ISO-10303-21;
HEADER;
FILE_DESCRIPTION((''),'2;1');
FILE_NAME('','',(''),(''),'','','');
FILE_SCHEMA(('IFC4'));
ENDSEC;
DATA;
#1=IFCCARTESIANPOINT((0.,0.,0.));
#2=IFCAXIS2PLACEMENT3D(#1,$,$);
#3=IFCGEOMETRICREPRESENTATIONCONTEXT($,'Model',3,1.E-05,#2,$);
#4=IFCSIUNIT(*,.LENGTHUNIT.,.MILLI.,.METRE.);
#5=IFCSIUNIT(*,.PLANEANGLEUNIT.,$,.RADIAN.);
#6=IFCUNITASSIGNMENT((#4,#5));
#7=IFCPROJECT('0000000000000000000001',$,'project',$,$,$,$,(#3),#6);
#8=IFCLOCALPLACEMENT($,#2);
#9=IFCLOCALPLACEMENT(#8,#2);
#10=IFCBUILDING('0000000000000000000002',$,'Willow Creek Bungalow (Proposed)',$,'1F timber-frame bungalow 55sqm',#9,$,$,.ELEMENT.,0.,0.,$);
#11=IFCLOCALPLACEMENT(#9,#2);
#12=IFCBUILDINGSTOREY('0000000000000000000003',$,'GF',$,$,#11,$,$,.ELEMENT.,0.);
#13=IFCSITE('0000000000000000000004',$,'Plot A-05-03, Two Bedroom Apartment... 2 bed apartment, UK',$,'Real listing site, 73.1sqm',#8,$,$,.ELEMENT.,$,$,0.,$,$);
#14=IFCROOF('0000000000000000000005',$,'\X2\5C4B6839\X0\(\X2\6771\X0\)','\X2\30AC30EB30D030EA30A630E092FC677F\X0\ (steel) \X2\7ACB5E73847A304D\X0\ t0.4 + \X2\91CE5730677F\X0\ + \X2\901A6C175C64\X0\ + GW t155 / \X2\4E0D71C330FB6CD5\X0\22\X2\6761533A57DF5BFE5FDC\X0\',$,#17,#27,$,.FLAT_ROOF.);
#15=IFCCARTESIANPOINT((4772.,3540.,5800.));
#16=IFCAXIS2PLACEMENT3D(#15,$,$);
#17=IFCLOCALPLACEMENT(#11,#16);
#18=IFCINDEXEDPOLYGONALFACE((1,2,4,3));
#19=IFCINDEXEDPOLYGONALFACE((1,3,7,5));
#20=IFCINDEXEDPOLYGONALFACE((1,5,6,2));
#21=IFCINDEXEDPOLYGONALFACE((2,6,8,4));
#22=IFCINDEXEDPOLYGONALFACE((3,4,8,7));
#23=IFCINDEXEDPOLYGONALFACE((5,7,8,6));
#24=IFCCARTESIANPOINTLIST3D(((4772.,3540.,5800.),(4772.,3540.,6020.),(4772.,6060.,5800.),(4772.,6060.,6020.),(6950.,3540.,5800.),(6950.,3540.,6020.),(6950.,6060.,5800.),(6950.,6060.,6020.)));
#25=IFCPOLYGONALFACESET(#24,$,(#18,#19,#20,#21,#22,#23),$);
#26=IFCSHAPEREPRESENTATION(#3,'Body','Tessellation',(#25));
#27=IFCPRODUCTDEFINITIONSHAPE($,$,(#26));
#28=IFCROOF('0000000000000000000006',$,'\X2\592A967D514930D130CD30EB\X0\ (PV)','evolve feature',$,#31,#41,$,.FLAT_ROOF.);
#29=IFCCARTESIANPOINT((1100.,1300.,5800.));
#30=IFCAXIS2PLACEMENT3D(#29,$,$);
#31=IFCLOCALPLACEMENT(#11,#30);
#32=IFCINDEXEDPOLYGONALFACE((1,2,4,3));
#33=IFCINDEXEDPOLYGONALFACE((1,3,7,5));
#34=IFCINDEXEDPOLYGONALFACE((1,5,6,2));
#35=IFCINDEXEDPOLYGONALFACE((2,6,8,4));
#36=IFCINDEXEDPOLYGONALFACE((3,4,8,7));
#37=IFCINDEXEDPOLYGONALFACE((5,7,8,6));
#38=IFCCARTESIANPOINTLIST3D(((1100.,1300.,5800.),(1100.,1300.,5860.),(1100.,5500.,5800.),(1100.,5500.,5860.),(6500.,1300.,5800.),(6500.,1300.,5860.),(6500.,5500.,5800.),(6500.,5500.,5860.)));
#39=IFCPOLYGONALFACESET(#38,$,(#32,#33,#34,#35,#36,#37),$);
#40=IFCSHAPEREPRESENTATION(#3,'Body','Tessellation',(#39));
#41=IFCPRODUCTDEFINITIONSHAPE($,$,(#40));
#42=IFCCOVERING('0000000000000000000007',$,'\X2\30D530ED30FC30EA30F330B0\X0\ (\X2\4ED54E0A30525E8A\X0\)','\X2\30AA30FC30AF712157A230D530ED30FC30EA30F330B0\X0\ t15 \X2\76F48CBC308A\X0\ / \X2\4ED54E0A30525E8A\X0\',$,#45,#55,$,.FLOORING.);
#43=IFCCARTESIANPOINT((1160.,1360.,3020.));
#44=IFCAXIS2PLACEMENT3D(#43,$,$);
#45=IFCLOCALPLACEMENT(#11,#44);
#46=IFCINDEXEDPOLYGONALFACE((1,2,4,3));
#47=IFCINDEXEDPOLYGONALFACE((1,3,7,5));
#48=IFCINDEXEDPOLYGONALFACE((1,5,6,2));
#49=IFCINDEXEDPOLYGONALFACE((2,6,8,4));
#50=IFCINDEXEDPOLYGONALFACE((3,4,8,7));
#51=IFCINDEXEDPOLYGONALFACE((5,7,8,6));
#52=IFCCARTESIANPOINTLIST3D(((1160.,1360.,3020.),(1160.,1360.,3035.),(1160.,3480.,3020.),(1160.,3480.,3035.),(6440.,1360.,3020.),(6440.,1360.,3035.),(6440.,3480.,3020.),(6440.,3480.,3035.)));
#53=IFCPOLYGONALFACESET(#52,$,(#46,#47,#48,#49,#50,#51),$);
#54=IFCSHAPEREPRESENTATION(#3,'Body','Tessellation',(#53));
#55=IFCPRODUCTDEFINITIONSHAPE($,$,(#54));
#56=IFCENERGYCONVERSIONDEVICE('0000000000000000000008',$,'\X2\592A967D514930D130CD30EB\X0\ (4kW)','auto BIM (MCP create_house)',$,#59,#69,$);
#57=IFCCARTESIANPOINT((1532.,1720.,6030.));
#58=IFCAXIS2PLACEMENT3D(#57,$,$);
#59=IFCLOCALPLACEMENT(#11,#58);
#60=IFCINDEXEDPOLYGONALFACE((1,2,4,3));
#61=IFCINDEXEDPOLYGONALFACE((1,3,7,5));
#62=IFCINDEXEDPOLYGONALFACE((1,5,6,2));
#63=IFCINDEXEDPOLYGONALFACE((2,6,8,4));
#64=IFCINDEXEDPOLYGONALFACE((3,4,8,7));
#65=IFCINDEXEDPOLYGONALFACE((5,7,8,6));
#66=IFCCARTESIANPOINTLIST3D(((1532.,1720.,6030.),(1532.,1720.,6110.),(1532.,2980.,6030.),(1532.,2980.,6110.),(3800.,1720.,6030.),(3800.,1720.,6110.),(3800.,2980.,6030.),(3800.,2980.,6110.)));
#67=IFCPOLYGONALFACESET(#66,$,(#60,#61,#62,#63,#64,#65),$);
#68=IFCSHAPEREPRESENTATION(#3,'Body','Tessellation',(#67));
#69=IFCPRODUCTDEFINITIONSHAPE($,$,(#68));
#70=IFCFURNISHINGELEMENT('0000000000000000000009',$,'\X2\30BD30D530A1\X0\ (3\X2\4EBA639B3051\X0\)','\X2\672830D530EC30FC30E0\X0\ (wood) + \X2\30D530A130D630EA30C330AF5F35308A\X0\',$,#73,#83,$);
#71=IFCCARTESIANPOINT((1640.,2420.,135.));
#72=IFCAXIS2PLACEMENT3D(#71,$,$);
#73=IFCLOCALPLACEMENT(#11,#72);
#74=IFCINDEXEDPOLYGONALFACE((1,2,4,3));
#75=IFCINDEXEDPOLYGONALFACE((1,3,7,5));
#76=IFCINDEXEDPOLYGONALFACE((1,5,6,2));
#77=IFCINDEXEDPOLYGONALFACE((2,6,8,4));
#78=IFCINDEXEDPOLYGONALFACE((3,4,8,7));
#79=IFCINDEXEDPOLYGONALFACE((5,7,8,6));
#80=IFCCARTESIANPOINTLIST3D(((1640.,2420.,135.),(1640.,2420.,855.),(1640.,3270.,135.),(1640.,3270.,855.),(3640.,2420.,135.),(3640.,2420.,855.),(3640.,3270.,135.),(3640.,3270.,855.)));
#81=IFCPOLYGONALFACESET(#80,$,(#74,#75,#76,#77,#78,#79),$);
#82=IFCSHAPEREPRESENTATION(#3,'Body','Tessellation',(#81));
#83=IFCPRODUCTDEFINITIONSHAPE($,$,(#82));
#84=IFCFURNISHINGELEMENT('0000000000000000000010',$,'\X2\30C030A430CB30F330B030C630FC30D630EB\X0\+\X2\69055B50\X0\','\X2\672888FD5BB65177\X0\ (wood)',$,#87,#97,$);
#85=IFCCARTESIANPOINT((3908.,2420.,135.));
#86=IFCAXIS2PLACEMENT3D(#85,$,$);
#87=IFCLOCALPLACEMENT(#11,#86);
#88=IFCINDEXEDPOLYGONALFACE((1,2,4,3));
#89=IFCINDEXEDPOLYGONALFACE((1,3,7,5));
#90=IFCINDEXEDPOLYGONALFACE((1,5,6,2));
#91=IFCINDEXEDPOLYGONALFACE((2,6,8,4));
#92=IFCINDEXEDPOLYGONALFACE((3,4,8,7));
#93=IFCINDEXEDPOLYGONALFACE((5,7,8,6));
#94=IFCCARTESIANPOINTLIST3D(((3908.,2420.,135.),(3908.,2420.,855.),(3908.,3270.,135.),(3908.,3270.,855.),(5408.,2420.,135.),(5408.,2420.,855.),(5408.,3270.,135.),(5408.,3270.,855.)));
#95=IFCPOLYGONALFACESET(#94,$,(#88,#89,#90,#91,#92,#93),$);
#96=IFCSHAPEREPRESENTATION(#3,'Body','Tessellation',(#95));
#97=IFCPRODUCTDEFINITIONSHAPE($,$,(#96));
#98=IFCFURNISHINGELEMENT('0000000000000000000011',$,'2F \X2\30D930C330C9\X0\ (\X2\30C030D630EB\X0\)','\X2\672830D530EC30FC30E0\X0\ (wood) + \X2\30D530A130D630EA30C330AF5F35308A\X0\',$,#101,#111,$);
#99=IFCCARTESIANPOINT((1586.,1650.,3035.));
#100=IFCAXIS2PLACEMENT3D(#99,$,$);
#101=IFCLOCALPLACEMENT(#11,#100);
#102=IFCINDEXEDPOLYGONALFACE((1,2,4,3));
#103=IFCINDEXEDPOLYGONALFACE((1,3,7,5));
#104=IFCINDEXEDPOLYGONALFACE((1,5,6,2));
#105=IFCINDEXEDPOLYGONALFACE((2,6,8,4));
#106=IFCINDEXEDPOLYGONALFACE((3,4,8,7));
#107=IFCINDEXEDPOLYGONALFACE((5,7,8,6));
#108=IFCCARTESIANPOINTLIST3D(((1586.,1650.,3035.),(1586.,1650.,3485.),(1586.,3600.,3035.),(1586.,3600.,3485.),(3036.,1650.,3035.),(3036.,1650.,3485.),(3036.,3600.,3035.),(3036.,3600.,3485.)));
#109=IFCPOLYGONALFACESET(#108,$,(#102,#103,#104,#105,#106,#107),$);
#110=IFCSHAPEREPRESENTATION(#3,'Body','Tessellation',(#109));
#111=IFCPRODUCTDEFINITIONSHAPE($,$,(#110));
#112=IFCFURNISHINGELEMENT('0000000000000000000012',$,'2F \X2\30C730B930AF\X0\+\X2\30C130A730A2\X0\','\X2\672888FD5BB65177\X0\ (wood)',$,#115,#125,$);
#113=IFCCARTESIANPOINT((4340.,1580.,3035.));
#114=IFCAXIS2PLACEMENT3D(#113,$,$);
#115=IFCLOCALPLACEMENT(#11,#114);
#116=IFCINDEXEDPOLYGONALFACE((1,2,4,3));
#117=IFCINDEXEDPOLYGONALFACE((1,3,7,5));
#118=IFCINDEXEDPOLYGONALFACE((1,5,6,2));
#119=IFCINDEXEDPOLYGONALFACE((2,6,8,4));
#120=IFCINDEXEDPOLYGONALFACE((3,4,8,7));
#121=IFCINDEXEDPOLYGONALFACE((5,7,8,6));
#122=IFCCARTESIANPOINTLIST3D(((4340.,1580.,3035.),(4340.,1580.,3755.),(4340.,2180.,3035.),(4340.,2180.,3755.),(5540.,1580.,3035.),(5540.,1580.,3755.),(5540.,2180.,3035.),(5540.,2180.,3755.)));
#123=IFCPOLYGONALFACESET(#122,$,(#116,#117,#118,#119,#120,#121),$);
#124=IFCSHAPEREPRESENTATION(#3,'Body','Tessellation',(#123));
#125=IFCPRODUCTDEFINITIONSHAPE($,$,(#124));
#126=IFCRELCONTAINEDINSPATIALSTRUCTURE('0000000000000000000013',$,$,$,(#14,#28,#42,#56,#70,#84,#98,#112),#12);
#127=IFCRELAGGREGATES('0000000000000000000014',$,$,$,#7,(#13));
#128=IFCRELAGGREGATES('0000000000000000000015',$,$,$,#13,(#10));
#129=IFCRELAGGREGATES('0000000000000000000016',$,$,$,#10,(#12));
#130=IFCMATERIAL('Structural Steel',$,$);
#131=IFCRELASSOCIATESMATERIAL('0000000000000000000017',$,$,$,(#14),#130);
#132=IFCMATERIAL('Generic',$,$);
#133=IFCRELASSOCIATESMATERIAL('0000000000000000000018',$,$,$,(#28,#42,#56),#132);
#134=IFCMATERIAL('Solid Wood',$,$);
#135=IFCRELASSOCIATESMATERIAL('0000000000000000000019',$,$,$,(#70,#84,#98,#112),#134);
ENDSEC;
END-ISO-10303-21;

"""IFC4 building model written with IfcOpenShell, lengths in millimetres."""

from ifc_helpers import new_model, si_unit, frame, frame_2d, origin, place, context, project, spatial, rectangle, extrude, material, element, save


model = new_model("IFC4")

# Units and contexts
model_context = context("Model", 3, precision=1e-05, world=origin())
ifc_project = project(units=[si_unit("LENGTHUNIT", "METRE", prefix="MILLI"), si_unit("PLANEANGLEUNIT", "RADIAN")], contexts=[model_context])

# Site, building, storey
site_placement = place(None, origin())
site = spatial("IfcSite", under=ifc_project, at=site_placement, Name="Plot A-05-03, Two Bedroom Apartment... 2 bed apartment, UK", ObjectType="Real listing site, 73.1sqm", CompositionType="ELEMENT", RefElevation=0.0)
building_placement = place(site_placement, origin())
building = spatial("IfcBuilding", under=site, at=building_placement, Name="Willow Creek Bungalow (Proposed)", ObjectType="1F timber-frame bungalow 55sqm", CompositionType="ELEMENT", ElevationOfRefHeight=0.0, ElevationOfTerrain=0.0)
storey_placement = place(building_placement, origin())
storey = spatial("IfcBuildingStorey", under=building, at=storey_placement, Name="GF", CompositionType="ELEMENT", Elevation=0.0)

# Shared definitions
ifc_material_1 = material(Name="Solid Wood")

# Roofs
ifc_material_2 = material(Name="Structural Steel")
roof_1_placement = place(storey_placement, frame((4772.0, 3540.0, 5800.0)))
element("IfcRoof", 1, at=roof_1_placement, inside=storey, material=ifc_material_2, Name="屋根(東)", Description="ガルバリウム鋼板 (steel) 立平葺き t0.4 + 野地板 + 通気層 + GW t155 / 不燃・法22条区域対応", PredefinedType="FLAT_ROOF", context=model_context, shape_type="SweptSolid", body=[
    extrude(rectangle(XDim=2178.0, YDim=2520.0, at=frame_2d((1089.0, 1260.0))), frame((4772.0, 3540.0, 5800.0)), (0.0, 0.0, 1.0), 220.0),
])
ifc_material_3 = material(Name="Generic")
roof_2_placement = place(storey_placement, frame((1100.0, 1300.0, 5800.0)))
element("IfcRoof", 2, at=roof_2_placement, inside=storey, material=ifc_material_3, Name="太陽光パネル (PV)", Description="evolve feature", PredefinedType="FLAT_ROOF", context=model_context, shape_type="SweptSolid", body=[
    extrude(rectangle(XDim=5400.0, YDim=4200.0, at=frame_2d((2700.0, 2100.0))), frame((1100.0, 1300.0, 5800.0)), (0.0, 0.0, 1.0), 60.0),
])

# Covering
covering_placement = place(storey_placement, frame((1160.0, 1360.0, 3020.0)))
element("IfcCovering", 3, at=covering_placement, inside=storey, material=ifc_material_3, Name="フローリング (仕上げ床)", Description="オーク無垢フローリング t15 直貼り / 仕上げ床", PredefinedType="FLOORING", context=model_context, shape_type="SweptSolid", body=[
    extrude(rectangle(XDim=5280.0, YDim=2120.0, at=frame_2d((2640.0, 1060.0))), frame((1160.0, 1360.0, 3020.0)), (0.0, 0.0, 1.0), 15.0),
])

# Energy conversion device
energy_conversion_device_placement = place(storey_placement, frame((1532.0, 1720.0, 6030.0)))
element("IfcEnergyConversionDevice", 4, at=energy_conversion_device_placement, inside=storey, material=ifc_material_3, Name="太陽光パネル (4kW)", Description="auto BIM (MCP create_house)", context=model_context, shape_type="SweptSolid", body=[
    extrude(rectangle(XDim=2268.0, YDim=1260.0, at=frame_2d((1134.0, 630.0))), frame((1532.0, 1720.0, 6030.0)), (0.0, 0.0, 1.0), 80.0),
])

# Furnishing elements
furnishing_1_placement = place(storey_placement, frame((1640.0, 2420.0, 135.0)))
element("IfcFurnishingElement", 5, at=furnishing_1_placement, inside=storey, material=ifc_material_1, Name="ソファ (3人掛け)", Description="木フレーム (wood) + ファブリック張り", context=model_context, shape_type="SweptSolid", body=[
    extrude(rectangle(XDim=2000.0, YDim=850.0, at=frame_2d((1000.0, 425.0))), frame((1640.0, 2420.0, 135.0)), (0.0, 0.0, 1.0), 720.0),
])
furnishing_2_placement = place(storey_placement, frame((3908.0, 2420.0, 135.0)))
element("IfcFurnishingElement", 6, at=furnishing_2_placement, inside=storey, material=ifc_material_1, Name="ダイニングテーブル+椅子", Description="木製家具 (wood)", context=model_context, shape_type="SweptSolid", body=[
    extrude(rectangle(XDim=1500.0, YDim=850.0, at=frame_2d((750.0, 425.0))), frame((3908.0, 2420.0, 135.0)), (0.0, 0.0, 1.0), 720.0),
])
furnishing_3_placement = place(storey_placement, frame((1586.0, 1650.0, 3035.0)))
element("IfcFurnishingElement", 7, at=furnishing_3_placement, inside=storey, material=ifc_material_1, Name="2F ベッド (ダブル)", Description="木フレーム (wood) + ファブリック張り", context=model_context, shape_type="SweptSolid", body=[
    extrude(rectangle(XDim=1450.0, YDim=1950.0, at=frame_2d((725.0, 975.0))), frame((1586.0, 1650.0, 3035.0)), (0.0, 0.0, 1.0), 450.0),
])
furnishing_4_placement = place(storey_placement, frame((4340.0, 1580.0, 3035.0)))
element("IfcFurnishingElement", 8, at=furnishing_4_placement, inside=storey, material=ifc_material_1, Name="2F デスク+チェア", Description="木製家具 (wood)", context=model_context, shape_type="SweptSolid", body=[
    extrude(rectangle(XDim=1200.0, YDim=600.0, at=frame_2d((600.0, 300.0))), frame((4340.0, 1580.0, 3035.0)), (0.0, 0.0, 1.0), 720.0),
])

save(model, "model.ifc")
